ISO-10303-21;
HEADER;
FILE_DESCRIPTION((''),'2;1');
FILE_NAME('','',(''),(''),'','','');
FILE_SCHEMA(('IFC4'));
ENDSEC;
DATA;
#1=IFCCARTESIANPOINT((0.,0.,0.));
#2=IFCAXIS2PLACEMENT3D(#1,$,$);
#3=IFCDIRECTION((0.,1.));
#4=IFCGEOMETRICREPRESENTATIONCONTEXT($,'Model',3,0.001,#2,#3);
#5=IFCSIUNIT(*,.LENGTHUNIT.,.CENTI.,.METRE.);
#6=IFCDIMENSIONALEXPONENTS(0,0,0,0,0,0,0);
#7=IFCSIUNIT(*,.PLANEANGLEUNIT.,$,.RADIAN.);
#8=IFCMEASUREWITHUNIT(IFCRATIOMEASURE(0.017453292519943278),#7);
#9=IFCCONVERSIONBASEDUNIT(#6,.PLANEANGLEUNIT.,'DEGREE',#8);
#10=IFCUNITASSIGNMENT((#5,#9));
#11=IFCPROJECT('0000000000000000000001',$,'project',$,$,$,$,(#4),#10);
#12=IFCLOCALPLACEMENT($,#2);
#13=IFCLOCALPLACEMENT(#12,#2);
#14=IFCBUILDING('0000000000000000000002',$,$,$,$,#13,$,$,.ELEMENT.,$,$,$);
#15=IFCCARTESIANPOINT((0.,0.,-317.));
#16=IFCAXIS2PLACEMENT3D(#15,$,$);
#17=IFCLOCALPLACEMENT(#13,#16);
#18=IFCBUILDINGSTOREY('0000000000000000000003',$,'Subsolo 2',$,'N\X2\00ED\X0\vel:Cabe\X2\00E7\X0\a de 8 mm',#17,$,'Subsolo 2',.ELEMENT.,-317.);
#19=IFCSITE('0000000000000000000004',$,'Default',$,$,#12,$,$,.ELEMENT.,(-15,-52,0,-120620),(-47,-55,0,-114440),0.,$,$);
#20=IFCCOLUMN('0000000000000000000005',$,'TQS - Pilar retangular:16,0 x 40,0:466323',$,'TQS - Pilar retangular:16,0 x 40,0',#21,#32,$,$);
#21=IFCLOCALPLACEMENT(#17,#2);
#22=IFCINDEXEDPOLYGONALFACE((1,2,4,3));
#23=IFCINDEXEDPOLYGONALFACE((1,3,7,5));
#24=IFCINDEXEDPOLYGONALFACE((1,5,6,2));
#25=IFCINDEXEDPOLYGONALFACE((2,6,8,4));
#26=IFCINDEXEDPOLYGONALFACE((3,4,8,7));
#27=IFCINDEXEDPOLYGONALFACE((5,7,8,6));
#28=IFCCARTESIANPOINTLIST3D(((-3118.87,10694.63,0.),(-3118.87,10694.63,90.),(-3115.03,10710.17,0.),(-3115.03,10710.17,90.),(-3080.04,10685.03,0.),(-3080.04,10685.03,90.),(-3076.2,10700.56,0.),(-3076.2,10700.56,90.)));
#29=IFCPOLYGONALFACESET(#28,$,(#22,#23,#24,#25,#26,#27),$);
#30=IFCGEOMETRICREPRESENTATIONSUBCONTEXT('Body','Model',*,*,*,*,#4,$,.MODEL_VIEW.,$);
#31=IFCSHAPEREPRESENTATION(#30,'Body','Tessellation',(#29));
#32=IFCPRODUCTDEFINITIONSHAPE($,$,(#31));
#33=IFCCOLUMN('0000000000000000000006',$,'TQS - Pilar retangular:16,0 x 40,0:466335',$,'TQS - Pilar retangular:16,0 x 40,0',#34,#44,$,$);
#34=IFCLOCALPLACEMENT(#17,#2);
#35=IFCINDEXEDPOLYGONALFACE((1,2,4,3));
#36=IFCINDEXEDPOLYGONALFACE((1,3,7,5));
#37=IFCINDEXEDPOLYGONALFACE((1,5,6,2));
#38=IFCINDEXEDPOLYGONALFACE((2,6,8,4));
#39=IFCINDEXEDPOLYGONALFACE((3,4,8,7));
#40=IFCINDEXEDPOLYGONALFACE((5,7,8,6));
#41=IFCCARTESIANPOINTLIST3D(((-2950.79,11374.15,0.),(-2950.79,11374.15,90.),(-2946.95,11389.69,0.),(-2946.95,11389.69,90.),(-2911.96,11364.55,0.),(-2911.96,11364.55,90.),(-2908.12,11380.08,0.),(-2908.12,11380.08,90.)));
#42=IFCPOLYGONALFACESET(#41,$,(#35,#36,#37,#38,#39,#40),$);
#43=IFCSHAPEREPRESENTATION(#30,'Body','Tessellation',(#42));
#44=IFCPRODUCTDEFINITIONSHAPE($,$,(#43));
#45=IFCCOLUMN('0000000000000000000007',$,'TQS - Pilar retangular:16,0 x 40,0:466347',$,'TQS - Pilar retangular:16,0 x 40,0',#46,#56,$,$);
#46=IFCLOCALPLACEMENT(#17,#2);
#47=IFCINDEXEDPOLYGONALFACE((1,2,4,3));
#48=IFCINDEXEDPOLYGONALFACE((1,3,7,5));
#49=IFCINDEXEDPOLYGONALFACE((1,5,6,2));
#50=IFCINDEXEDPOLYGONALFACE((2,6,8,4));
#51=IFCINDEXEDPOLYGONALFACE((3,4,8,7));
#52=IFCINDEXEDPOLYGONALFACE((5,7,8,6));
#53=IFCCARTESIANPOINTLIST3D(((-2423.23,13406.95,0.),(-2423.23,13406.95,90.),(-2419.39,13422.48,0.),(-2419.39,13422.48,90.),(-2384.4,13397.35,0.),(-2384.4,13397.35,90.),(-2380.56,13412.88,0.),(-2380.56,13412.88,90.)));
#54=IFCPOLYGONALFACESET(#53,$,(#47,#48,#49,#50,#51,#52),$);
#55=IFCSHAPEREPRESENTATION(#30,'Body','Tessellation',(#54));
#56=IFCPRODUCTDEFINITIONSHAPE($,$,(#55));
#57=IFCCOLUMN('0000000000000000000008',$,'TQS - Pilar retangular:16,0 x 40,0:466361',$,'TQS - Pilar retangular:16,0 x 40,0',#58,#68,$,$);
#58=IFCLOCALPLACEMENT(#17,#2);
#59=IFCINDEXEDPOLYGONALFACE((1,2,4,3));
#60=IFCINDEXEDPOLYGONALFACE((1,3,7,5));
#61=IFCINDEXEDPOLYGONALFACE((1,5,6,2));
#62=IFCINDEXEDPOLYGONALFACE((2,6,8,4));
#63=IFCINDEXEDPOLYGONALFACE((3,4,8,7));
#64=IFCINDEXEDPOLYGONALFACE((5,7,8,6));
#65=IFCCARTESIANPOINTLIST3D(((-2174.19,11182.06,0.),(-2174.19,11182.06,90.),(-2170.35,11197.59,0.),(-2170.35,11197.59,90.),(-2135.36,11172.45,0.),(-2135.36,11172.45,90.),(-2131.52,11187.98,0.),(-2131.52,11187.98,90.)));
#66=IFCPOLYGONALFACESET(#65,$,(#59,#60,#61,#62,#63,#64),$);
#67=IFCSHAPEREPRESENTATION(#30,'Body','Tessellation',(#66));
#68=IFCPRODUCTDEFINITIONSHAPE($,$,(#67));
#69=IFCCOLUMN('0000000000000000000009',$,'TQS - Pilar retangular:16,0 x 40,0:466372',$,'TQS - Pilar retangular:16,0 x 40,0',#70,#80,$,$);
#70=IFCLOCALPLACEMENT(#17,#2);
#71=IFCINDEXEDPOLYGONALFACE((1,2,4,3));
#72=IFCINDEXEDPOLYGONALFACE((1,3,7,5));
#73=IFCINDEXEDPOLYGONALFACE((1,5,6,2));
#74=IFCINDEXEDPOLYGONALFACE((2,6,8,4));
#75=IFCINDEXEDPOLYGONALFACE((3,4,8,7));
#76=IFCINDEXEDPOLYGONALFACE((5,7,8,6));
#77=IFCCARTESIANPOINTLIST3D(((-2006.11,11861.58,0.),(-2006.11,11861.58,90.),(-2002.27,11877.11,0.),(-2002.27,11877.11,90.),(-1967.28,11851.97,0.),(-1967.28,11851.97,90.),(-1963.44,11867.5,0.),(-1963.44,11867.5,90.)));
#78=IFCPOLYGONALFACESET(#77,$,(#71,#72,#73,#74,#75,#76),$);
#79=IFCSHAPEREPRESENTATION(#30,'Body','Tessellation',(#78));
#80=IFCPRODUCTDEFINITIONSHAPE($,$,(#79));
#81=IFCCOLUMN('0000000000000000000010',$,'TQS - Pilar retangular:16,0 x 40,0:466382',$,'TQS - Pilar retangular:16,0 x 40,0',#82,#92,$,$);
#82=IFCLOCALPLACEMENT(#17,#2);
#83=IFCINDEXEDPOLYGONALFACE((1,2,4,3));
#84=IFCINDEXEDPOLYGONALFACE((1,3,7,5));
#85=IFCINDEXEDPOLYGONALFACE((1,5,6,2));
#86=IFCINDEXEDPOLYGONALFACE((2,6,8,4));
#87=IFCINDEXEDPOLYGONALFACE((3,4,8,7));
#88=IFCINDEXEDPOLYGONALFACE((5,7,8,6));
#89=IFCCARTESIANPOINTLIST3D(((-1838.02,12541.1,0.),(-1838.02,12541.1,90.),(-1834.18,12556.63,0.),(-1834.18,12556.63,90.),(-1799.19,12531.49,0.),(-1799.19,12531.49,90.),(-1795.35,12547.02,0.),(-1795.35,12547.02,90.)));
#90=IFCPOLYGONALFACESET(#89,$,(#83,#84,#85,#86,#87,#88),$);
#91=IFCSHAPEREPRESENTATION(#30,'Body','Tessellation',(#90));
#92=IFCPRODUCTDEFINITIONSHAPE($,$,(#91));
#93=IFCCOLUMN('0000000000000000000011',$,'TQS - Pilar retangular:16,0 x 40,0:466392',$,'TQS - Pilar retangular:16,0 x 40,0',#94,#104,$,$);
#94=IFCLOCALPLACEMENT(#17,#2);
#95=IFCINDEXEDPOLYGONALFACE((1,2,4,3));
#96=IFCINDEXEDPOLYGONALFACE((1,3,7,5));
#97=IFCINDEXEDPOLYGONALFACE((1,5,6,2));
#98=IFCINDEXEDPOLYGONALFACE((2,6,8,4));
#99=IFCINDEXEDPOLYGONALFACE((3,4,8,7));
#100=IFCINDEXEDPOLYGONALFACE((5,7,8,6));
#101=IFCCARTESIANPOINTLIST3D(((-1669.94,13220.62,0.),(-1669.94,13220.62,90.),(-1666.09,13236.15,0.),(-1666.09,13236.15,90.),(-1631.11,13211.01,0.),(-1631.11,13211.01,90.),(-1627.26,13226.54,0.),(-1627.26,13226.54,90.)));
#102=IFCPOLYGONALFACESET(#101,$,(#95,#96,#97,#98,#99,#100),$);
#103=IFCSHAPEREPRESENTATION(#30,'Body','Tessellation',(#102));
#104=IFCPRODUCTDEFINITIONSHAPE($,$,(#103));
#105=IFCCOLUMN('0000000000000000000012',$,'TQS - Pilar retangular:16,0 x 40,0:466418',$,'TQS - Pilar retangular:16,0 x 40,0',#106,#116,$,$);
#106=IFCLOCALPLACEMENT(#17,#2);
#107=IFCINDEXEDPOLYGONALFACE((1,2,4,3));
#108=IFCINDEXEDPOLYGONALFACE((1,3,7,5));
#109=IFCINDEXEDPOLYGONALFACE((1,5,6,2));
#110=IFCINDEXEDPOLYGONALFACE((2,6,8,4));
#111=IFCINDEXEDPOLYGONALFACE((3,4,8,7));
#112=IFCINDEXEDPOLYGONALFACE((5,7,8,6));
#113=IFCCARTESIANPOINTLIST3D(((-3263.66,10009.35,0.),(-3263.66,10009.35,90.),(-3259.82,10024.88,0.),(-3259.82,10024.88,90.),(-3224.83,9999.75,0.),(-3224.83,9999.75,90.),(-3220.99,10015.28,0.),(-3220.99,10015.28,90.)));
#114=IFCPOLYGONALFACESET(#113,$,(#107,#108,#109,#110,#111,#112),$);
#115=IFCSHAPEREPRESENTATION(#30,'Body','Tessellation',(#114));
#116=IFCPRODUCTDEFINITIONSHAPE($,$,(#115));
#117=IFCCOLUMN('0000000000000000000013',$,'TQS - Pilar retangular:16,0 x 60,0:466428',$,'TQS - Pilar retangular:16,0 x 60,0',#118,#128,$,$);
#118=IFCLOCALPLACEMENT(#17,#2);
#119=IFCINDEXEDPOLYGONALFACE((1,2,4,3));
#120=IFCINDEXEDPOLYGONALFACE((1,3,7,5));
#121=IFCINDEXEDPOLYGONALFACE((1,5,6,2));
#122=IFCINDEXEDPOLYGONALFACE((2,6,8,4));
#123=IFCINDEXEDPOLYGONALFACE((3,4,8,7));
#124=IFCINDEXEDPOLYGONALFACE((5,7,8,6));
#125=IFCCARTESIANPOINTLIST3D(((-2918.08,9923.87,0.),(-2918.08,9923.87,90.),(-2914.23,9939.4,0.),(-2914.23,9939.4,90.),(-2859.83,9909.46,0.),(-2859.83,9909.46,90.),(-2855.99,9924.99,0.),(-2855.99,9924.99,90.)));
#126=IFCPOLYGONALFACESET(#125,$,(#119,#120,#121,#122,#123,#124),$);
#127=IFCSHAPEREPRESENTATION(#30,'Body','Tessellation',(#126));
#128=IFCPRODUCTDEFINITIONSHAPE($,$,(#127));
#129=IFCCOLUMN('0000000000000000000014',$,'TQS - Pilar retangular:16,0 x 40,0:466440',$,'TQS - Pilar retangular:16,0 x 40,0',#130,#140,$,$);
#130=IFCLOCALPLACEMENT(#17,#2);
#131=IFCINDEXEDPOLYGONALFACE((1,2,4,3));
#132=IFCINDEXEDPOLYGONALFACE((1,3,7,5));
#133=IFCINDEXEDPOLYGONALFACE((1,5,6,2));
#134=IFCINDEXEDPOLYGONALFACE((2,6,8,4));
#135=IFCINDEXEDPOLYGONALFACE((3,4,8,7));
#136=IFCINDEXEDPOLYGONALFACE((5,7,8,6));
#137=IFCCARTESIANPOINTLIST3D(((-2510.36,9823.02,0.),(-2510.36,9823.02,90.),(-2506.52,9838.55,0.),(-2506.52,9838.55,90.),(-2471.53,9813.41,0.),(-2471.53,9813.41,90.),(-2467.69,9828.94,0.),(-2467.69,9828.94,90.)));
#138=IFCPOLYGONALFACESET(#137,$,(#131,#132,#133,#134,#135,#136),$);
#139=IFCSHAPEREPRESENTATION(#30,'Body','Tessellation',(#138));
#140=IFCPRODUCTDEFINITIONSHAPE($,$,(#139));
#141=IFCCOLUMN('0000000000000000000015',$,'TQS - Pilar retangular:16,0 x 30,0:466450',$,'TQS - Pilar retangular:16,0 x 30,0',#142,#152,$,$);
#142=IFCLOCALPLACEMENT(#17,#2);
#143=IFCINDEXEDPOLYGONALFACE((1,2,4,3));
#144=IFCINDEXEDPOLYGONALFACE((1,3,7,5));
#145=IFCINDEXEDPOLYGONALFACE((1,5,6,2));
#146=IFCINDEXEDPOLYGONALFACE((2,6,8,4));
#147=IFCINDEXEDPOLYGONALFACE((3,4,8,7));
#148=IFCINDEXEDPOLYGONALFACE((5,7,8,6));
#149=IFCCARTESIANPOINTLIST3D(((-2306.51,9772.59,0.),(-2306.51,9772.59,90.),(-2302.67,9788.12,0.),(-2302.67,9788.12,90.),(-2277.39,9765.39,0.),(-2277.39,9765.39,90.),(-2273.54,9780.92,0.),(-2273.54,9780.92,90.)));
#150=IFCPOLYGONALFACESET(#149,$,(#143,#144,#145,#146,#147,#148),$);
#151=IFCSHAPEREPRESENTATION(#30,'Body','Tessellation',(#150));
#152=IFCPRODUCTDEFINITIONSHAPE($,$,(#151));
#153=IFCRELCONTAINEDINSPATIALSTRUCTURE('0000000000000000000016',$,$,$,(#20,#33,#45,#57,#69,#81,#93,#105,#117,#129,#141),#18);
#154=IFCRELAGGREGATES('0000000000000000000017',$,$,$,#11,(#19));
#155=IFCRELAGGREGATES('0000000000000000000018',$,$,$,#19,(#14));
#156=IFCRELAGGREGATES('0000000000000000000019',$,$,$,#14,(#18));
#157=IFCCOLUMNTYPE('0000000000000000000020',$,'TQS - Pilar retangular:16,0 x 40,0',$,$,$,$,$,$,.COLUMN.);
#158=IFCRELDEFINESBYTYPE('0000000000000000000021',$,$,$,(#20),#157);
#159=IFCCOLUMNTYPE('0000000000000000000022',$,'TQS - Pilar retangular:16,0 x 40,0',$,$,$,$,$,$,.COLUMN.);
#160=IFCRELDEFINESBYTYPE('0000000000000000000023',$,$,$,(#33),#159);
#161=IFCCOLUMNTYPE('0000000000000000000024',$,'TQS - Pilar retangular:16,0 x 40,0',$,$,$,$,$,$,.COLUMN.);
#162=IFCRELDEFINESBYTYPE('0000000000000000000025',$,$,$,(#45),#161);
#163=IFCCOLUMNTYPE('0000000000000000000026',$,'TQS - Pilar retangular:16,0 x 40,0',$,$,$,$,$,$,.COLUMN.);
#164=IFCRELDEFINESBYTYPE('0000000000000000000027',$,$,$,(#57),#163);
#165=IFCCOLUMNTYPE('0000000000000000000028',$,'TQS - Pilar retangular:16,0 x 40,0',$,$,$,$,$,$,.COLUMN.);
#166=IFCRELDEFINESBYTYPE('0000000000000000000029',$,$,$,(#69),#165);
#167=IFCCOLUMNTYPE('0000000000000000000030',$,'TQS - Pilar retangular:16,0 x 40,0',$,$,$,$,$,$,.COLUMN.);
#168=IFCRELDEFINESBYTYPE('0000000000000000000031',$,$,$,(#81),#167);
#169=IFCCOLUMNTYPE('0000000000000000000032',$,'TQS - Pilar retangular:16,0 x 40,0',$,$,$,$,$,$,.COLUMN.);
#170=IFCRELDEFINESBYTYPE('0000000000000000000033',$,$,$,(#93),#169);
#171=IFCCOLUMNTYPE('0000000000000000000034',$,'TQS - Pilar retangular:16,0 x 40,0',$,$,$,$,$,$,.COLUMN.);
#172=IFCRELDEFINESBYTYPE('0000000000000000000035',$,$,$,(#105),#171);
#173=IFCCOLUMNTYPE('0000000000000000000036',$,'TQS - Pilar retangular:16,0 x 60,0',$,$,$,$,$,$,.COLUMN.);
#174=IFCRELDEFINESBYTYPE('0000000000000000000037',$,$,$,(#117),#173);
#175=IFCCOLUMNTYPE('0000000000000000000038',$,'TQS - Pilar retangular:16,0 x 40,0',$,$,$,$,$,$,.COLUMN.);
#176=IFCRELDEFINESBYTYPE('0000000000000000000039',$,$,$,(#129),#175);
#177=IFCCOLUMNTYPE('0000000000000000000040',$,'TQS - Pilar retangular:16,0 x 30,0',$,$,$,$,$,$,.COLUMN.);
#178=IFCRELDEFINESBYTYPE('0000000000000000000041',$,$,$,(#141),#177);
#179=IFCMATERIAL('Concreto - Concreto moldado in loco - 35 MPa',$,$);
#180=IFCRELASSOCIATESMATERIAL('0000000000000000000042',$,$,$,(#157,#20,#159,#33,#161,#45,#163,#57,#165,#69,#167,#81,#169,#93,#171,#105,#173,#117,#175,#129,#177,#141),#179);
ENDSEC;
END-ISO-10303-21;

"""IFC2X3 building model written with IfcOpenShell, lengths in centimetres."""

from ifc_helpers import new_model, entity, si_unit, converted_unit, direction, frame, origin, origin_2d_with_axis, place, context, subcontext, project, spatial, rectangle, extrude, source, transform, mapped, material, type_object, type_shapes, element, save


model = new_model("IFC2X3")

# Units and contexts
model_context = context("Model", 3, precision=0.001, world=origin(), true_north=direction((0.0, 1.0)))
body_context = subcontext(model_context, "Body", "Model", "MODEL_VIEW")
ifc_project = project(units=[si_unit("LENGTHUNIT", "METRE", prefix="CENTI"), converted_unit("PLANEANGLEUNIT", "DEGREE", entity("IfcRatioMeasure", 0.017453292519943278), si_unit("PLANEANGLEUNIT", "RADIAN"), dimensions=[0, 0, 0, 0, 0, 0, 0])], contexts=[model_context])

# Site, building, storey
site_placement = place(None, origin())
site = spatial("IfcSite", under=ifc_project, at=site_placement, Name="Default", CompositionType="ELEMENT", RefLatitude=(-15, -52, 0, -120620), RefLongitude=(-47, -55, 0, -114440), RefElevation=0.0)
building_placement = place(site_placement, origin())
building = spatial("IfcBuilding", under=site, at=building_placement, CompositionType="ELEMENT")
storey_placement = place(building_placement, frame((0.0, 0.0, -317.0)))
storey = spatial("IfcBuildingStorey", under=building, at=storey_placement, Name="Subsolo 2", ObjectType="Nível:Cabeça de 8 mm", LongName="Subsolo 2", CompositionType="ELEMENT", Elevation=-317.0)

# Columns
ifc_material = material(Name="Concreto - Concreto moldado in loco - 35 MPa")
column_type_1 = type_object("IfcColumnType", Name="TQS - Pilar retangular:16,0 x 40,0", PredefinedType="COLUMN", material=ifc_material)
shared_shape_1 = source(origin(), body_context, "Body", "SweptSolid", [
    extrude(rectangle(XDim=40.0, YDim=16.0, at=origin_2d_with_axis()), frame((-3097.54, 10697.6, -317.0), z_axis=(0.0, 0.0, 1.0), x_axis=(-0.970743, 0.240122, 0.0)), (0.0, 0.0, 1.0), 90.0),
])
type_shapes(column_type_1, [shared_shape_1])
column_1_placement = place(storey_placement, frame((0.0, 0.0, 317.0)))
element("IfcColumn", 1, at=column_1_placement, inside=storey, type_object=column_type_1, material=ifc_material, Name="TQS - Pilar retangular:16,0 x 40,0:466323", ObjectType="TQS - Pilar retangular:16,0 x 40,0", context=body_context, shape_type="MappedRepresentation", body=[
    mapped(shared_shape_1, transform((0.0, 0.0, 0.0), scale=1.0)),
])
column_type_2 = type_object("IfcColumnType", Name="TQS - Pilar retangular:16,0 x 40,0", PredefinedType="COLUMN", material=ifc_material)
shared_shape_2 = source(origin(), body_context, "Body", "SweptSolid", [
    extrude(rectangle(XDim=40.0, YDim=16.0, at=origin_2d_with_axis()), frame((-2929.45, 11377.12, -317.0), z_axis=(0.0, 0.0, 1.0), x_axis=(-0.970743, 0.240122, 0.0)), (0.0, 0.0, 1.0), 90.0),
])
type_shapes(column_type_2, [shared_shape_2])
column_2_placement = place(storey_placement, frame((0.0, 0.0, 317.0)))
element("IfcColumn", 2, at=column_2_placement, inside=storey, type_object=column_type_2, material=ifc_material, Name="TQS - Pilar retangular:16,0 x 40,0:466335", ObjectType="TQS - Pilar retangular:16,0 x 40,0", context=body_context, shape_type="MappedRepresentation", body=[
    mapped(shared_shape_2, transform((0.0, 0.0, 0.0), scale=1.0)),
])
column_type_3 = type_object("IfcColumnType", Name="TQS - Pilar retangular:16,0 x 40,0", PredefinedType="COLUMN", material=ifc_material)
shared_shape_3 = source(origin(), body_context, "Body", "SweptSolid", [
    extrude(rectangle(XDim=40.0, YDim=16.0, at=origin_2d_with_axis()), frame((-2401.9, 13409.91, -317.0), z_axis=(0.0, 0.0, 1.0), x_axis=(-0.970743, 0.240122, 0.0)), (0.0, 0.0, 1.0), 90.0),
])
type_shapes(column_type_3, [shared_shape_3])
column_3_placement = place(storey_placement, frame((0.0, 0.0, 317.0)))
element("IfcColumn", 3, at=column_3_placement, inside=storey, type_object=column_type_3, material=ifc_material, Name="TQS - Pilar retangular:16,0 x 40,0:466347", ObjectType="TQS - Pilar retangular:16,0 x 40,0", context=body_context, shape_type="MappedRepresentation", body=[
    mapped(shared_shape_3, transform((0.0, 0.0, 0.0), scale=1.0)),
])
column_type_4 = type_object("IfcColumnType", Name="TQS - Pilar retangular:16,0 x 40,0", PredefinedType="COLUMN", material=ifc_material)
shared_shape_4 = source(origin(), body_context, "Body", "SweptSolid", [
    extrude(rectangle(XDim=40.0, YDim=16.0, at=origin_2d_with_axis()), frame((-2152.86, 11185.02, -317.0), z_axis=(0.0, 0.0, 1.0), x_axis=(-0.970743, 0.240122, 0.0)), (0.0, 0.0, 1.0), 90.0),
])
type_shapes(column_type_4, [shared_shape_4])
column_4_placement = place(storey_placement, frame((0.0, 0.0, 317.0)))
element("IfcColumn", 4, at=column_4_placement, inside=storey, type_object=column_type_4, material=ifc_material, Name="TQS - Pilar retangular:16,0 x 40,0:466361", ObjectType="TQS - Pilar retangular:16,0 x 40,0", context=body_context, shape_type="MappedRepresentation", body=[
    mapped(shared_shape_4, transform((0.0, 0.0, 0.0), scale=1.0)),
])
column_type_5 = type_object("IfcColumnType", Name="TQS - Pilar retangular:16,0 x 40,0", PredefinedType="COLUMN", material=ifc_material)
shared_shape_5 = source(origin(), body_context, "Body", "SweptSolid", [
    extrude(rectangle(XDim=40.0, YDim=16.0, at=origin_2d_with_axis()), frame((-1984.77, 11864.54, -317.0), z_axis=(0.0, 0.0, 1.0), x_axis=(-0.970743, 0.240122, 0.0)), (0.0, 0.0, 1.0), 90.0),
])
type_shapes(column_type_5, [shared_shape_5])
column_5_placement = place(storey_placement, frame((0.0, 0.0, 317.0)))
element("IfcColumn", 5, at=column_5_placement, inside=storey, type_object=column_type_5, material=ifc_material, Name="TQS - Pilar retangular:16,0 x 40,0:466372", ObjectType="TQS - Pilar retangular:16,0 x 40,0", context=body_context, shape_type="MappedRepresentation", body=[
    mapped(shared_shape_5, transform((0.0, 0.0, 0.0), scale=1.0)),
])
column_type_6 = type_object("IfcColumnType", Name="TQS - Pilar retangular:16,0 x 40,0", PredefinedType="COLUMN", material=ifc_material)
shared_shape_6 = source(origin(), body_context, "Body", "SweptSolid", [
    extrude(rectangle(XDim=40.0, YDim=16.0, at=origin_2d_with_axis()), frame((-1816.69, 12544.06, -317.0), z_axis=(0.0, 0.0, 1.0), x_axis=(-0.970743, 0.240122, 0.0)), (0.0, 0.0, 1.0), 90.0),
])
type_shapes(column_type_6, [shared_shape_6])
column_6_placement = place(storey_placement, frame((0.0, 0.0, 317.0)))
element("IfcColumn", 6, at=column_6_placement, inside=storey, type_object=column_type_6, material=ifc_material, Name="TQS - Pilar retangular:16,0 x 40,0:466382", ObjectType="TQS - Pilar retangular:16,0 x 40,0", context=body_context, shape_type="MappedRepresentation", body=[
    mapped(shared_shape_6, transform((0.0, 0.0, 0.0), scale=1.0)),
])
column_type_7 = type_object("IfcColumnType", Name="TQS - Pilar retangular:16,0 x 40,0", PredefinedType="COLUMN", material=ifc_material)
shared_shape_7 = source(origin(), body_context, "Body", "SweptSolid", [
    extrude(rectangle(XDim=40.0, YDim=16.0, at=origin_2d_with_axis()), frame((-1648.6, 13223.58, -317.0), z_axis=(0.0, 0.0, 1.0), x_axis=(-0.970743, 0.240122, 0.0)), (0.0, 0.0, 1.0), 90.0),
])
type_shapes(column_type_7, [shared_shape_7])
column_7_placement = place(storey_placement, frame((0.0, 0.0, 317.0)))
element("IfcColumn", 7, at=column_7_placement, inside=storey, type_object=column_type_7, material=ifc_material, Name="TQS - Pilar retangular:16,0 x 40,0:466392", ObjectType="TQS - Pilar retangular:16,0 x 40,0", context=body_context, shape_type="MappedRepresentation", body=[
    mapped(shared_shape_7, transform((0.0, 0.0, 0.0), scale=1.0)),
])
column_type_8 = type_object("IfcColumnType", Name="TQS - Pilar retangular:16,0 x 40,0", PredefinedType="COLUMN", material=ifc_material)
shared_shape_8 = source(origin(), body_context, "Body", "SweptSolid", [
    extrude(rectangle(XDim=40.0, YDim=16.0, at=origin_2d_with_axis()), frame((-3242.33, 10012.31, -317.0), z_axis=(0.0, 0.0, 1.0), x_axis=(-0.970743, 0.240122, 0.0)), (0.0, 0.0, 1.0), 90.0),
])
type_shapes(column_type_8, [shared_shape_8])
column_8_placement = place(storey_placement, frame((0.0, 0.0, 317.0)))
element("IfcColumn", 8, at=column_8_placement, inside=storey, type_object=column_type_8, material=ifc_material, Name="TQS - Pilar retangular:16,0 x 40,0:466418", ObjectType="TQS - Pilar retangular:16,0 x 40,0", context=body_context, shape_type="MappedRepresentation", body=[
    mapped(shared_shape_8, transform((0.0, 0.0, 0.0), scale=1.0)),
])
column_type_9 = type_object("IfcColumnType", Name="TQS - Pilar retangular:16,0 x 60,0", PredefinedType="COLUMN", material=ifc_material)
shared_shape_9 = source(origin(), body_context, "Body", "SweptSolid", [
    extrude(rectangle(XDim=60.0, YDim=16.0, at=origin_2d_with_axis()), frame((-2887.03, 9924.43, -317.0), z_axis=(0.0, 0.0, 1.0), x_axis=(-0.970743, 0.240122, 0.0)), (0.0, 0.0, 1.0), 90.0),
])
type_shapes(column_type_9, [shared_shape_9])
column_9_placement = place(storey_placement, frame((0.0, 0.0, 317.0)))
element("IfcColumn", 9, at=column_9_placement, inside=storey, type_object=column_type_9, material=ifc_material, Name="TQS - Pilar retangular:16,0 x 60,0:466428", ObjectType="TQS - Pilar retangular:16,0 x 60,0", context=body_context, shape_type="MappedRepresentation", body=[
    mapped(shared_shape_9, transform((0.0, 0.0, 0.0), scale=1.0)),
])
column_type_10 = type_object("IfcColumnType", Name="TQS - Pilar retangular:16,0 x 40,0", PredefinedType="COLUMN", material=ifc_material)
shared_shape_10 = source(origin(), body_context, "Body", "SweptSolid", [
    extrude(rectangle(XDim=40.0, YDim=16.0, at=origin_2d_with_axis()), frame((-2489.03, 9825.98, -317.0), z_axis=(0.0, 0.0, 1.0), x_axis=(-0.970743, 0.240122, 0.0)), (0.0, 0.0, 1.0), 90.0),
])
type_shapes(column_type_10, [shared_shape_10])
column_10_placement = place(storey_placement, frame((0.0, 0.0, 317.0)))
element("IfcColumn", 10, at=column_10_placement, inside=storey, type_object=column_type_10, material=ifc_material, Name="TQS - Pilar retangular:16,0 x 40,0:466440", ObjectType="TQS - Pilar retangular:16,0 x 40,0", context=body_context, shape_type="MappedRepresentation", body=[
    mapped(shared_shape_10, transform((0.0, 0.0, 0.0), scale=1.0)),
])
column_type_11 = type_object("IfcColumnType", Name="TQS - Pilar retangular:16,0 x 30,0", PredefinedType="COLUMN", material=ifc_material)
shared_shape_11 = source(origin(), body_context, "Body", "SweptSolid", [
    extrude(rectangle(XDim=30.0, YDim=16.0, at=origin_2d_with_axis()), frame((-2290.03, 9776.75, -317.0), z_axis=(0.0, 0.0, 1.0), x_axis=(-0.970743, 0.240122, 0.0)), (0.0, 0.0, 1.0), 90.0),
])
type_shapes(column_type_11, [shared_shape_11])
column_11_placement = place(storey_placement, frame((0.0, 0.0, 317.0)))
element("IfcColumn", 11, at=column_11_placement, inside=storey, type_object=column_type_11, material=ifc_material, Name="TQS - Pilar retangular:16,0 x 30,0:466450", ObjectType="TQS - Pilar retangular:16,0 x 30,0", context=body_context, shape_type="MappedRepresentation", body=[
    mapped(shared_shape_11, transform((0.0, 0.0, 0.0), scale=1.0)),
])

save(model, "model.ifc")
